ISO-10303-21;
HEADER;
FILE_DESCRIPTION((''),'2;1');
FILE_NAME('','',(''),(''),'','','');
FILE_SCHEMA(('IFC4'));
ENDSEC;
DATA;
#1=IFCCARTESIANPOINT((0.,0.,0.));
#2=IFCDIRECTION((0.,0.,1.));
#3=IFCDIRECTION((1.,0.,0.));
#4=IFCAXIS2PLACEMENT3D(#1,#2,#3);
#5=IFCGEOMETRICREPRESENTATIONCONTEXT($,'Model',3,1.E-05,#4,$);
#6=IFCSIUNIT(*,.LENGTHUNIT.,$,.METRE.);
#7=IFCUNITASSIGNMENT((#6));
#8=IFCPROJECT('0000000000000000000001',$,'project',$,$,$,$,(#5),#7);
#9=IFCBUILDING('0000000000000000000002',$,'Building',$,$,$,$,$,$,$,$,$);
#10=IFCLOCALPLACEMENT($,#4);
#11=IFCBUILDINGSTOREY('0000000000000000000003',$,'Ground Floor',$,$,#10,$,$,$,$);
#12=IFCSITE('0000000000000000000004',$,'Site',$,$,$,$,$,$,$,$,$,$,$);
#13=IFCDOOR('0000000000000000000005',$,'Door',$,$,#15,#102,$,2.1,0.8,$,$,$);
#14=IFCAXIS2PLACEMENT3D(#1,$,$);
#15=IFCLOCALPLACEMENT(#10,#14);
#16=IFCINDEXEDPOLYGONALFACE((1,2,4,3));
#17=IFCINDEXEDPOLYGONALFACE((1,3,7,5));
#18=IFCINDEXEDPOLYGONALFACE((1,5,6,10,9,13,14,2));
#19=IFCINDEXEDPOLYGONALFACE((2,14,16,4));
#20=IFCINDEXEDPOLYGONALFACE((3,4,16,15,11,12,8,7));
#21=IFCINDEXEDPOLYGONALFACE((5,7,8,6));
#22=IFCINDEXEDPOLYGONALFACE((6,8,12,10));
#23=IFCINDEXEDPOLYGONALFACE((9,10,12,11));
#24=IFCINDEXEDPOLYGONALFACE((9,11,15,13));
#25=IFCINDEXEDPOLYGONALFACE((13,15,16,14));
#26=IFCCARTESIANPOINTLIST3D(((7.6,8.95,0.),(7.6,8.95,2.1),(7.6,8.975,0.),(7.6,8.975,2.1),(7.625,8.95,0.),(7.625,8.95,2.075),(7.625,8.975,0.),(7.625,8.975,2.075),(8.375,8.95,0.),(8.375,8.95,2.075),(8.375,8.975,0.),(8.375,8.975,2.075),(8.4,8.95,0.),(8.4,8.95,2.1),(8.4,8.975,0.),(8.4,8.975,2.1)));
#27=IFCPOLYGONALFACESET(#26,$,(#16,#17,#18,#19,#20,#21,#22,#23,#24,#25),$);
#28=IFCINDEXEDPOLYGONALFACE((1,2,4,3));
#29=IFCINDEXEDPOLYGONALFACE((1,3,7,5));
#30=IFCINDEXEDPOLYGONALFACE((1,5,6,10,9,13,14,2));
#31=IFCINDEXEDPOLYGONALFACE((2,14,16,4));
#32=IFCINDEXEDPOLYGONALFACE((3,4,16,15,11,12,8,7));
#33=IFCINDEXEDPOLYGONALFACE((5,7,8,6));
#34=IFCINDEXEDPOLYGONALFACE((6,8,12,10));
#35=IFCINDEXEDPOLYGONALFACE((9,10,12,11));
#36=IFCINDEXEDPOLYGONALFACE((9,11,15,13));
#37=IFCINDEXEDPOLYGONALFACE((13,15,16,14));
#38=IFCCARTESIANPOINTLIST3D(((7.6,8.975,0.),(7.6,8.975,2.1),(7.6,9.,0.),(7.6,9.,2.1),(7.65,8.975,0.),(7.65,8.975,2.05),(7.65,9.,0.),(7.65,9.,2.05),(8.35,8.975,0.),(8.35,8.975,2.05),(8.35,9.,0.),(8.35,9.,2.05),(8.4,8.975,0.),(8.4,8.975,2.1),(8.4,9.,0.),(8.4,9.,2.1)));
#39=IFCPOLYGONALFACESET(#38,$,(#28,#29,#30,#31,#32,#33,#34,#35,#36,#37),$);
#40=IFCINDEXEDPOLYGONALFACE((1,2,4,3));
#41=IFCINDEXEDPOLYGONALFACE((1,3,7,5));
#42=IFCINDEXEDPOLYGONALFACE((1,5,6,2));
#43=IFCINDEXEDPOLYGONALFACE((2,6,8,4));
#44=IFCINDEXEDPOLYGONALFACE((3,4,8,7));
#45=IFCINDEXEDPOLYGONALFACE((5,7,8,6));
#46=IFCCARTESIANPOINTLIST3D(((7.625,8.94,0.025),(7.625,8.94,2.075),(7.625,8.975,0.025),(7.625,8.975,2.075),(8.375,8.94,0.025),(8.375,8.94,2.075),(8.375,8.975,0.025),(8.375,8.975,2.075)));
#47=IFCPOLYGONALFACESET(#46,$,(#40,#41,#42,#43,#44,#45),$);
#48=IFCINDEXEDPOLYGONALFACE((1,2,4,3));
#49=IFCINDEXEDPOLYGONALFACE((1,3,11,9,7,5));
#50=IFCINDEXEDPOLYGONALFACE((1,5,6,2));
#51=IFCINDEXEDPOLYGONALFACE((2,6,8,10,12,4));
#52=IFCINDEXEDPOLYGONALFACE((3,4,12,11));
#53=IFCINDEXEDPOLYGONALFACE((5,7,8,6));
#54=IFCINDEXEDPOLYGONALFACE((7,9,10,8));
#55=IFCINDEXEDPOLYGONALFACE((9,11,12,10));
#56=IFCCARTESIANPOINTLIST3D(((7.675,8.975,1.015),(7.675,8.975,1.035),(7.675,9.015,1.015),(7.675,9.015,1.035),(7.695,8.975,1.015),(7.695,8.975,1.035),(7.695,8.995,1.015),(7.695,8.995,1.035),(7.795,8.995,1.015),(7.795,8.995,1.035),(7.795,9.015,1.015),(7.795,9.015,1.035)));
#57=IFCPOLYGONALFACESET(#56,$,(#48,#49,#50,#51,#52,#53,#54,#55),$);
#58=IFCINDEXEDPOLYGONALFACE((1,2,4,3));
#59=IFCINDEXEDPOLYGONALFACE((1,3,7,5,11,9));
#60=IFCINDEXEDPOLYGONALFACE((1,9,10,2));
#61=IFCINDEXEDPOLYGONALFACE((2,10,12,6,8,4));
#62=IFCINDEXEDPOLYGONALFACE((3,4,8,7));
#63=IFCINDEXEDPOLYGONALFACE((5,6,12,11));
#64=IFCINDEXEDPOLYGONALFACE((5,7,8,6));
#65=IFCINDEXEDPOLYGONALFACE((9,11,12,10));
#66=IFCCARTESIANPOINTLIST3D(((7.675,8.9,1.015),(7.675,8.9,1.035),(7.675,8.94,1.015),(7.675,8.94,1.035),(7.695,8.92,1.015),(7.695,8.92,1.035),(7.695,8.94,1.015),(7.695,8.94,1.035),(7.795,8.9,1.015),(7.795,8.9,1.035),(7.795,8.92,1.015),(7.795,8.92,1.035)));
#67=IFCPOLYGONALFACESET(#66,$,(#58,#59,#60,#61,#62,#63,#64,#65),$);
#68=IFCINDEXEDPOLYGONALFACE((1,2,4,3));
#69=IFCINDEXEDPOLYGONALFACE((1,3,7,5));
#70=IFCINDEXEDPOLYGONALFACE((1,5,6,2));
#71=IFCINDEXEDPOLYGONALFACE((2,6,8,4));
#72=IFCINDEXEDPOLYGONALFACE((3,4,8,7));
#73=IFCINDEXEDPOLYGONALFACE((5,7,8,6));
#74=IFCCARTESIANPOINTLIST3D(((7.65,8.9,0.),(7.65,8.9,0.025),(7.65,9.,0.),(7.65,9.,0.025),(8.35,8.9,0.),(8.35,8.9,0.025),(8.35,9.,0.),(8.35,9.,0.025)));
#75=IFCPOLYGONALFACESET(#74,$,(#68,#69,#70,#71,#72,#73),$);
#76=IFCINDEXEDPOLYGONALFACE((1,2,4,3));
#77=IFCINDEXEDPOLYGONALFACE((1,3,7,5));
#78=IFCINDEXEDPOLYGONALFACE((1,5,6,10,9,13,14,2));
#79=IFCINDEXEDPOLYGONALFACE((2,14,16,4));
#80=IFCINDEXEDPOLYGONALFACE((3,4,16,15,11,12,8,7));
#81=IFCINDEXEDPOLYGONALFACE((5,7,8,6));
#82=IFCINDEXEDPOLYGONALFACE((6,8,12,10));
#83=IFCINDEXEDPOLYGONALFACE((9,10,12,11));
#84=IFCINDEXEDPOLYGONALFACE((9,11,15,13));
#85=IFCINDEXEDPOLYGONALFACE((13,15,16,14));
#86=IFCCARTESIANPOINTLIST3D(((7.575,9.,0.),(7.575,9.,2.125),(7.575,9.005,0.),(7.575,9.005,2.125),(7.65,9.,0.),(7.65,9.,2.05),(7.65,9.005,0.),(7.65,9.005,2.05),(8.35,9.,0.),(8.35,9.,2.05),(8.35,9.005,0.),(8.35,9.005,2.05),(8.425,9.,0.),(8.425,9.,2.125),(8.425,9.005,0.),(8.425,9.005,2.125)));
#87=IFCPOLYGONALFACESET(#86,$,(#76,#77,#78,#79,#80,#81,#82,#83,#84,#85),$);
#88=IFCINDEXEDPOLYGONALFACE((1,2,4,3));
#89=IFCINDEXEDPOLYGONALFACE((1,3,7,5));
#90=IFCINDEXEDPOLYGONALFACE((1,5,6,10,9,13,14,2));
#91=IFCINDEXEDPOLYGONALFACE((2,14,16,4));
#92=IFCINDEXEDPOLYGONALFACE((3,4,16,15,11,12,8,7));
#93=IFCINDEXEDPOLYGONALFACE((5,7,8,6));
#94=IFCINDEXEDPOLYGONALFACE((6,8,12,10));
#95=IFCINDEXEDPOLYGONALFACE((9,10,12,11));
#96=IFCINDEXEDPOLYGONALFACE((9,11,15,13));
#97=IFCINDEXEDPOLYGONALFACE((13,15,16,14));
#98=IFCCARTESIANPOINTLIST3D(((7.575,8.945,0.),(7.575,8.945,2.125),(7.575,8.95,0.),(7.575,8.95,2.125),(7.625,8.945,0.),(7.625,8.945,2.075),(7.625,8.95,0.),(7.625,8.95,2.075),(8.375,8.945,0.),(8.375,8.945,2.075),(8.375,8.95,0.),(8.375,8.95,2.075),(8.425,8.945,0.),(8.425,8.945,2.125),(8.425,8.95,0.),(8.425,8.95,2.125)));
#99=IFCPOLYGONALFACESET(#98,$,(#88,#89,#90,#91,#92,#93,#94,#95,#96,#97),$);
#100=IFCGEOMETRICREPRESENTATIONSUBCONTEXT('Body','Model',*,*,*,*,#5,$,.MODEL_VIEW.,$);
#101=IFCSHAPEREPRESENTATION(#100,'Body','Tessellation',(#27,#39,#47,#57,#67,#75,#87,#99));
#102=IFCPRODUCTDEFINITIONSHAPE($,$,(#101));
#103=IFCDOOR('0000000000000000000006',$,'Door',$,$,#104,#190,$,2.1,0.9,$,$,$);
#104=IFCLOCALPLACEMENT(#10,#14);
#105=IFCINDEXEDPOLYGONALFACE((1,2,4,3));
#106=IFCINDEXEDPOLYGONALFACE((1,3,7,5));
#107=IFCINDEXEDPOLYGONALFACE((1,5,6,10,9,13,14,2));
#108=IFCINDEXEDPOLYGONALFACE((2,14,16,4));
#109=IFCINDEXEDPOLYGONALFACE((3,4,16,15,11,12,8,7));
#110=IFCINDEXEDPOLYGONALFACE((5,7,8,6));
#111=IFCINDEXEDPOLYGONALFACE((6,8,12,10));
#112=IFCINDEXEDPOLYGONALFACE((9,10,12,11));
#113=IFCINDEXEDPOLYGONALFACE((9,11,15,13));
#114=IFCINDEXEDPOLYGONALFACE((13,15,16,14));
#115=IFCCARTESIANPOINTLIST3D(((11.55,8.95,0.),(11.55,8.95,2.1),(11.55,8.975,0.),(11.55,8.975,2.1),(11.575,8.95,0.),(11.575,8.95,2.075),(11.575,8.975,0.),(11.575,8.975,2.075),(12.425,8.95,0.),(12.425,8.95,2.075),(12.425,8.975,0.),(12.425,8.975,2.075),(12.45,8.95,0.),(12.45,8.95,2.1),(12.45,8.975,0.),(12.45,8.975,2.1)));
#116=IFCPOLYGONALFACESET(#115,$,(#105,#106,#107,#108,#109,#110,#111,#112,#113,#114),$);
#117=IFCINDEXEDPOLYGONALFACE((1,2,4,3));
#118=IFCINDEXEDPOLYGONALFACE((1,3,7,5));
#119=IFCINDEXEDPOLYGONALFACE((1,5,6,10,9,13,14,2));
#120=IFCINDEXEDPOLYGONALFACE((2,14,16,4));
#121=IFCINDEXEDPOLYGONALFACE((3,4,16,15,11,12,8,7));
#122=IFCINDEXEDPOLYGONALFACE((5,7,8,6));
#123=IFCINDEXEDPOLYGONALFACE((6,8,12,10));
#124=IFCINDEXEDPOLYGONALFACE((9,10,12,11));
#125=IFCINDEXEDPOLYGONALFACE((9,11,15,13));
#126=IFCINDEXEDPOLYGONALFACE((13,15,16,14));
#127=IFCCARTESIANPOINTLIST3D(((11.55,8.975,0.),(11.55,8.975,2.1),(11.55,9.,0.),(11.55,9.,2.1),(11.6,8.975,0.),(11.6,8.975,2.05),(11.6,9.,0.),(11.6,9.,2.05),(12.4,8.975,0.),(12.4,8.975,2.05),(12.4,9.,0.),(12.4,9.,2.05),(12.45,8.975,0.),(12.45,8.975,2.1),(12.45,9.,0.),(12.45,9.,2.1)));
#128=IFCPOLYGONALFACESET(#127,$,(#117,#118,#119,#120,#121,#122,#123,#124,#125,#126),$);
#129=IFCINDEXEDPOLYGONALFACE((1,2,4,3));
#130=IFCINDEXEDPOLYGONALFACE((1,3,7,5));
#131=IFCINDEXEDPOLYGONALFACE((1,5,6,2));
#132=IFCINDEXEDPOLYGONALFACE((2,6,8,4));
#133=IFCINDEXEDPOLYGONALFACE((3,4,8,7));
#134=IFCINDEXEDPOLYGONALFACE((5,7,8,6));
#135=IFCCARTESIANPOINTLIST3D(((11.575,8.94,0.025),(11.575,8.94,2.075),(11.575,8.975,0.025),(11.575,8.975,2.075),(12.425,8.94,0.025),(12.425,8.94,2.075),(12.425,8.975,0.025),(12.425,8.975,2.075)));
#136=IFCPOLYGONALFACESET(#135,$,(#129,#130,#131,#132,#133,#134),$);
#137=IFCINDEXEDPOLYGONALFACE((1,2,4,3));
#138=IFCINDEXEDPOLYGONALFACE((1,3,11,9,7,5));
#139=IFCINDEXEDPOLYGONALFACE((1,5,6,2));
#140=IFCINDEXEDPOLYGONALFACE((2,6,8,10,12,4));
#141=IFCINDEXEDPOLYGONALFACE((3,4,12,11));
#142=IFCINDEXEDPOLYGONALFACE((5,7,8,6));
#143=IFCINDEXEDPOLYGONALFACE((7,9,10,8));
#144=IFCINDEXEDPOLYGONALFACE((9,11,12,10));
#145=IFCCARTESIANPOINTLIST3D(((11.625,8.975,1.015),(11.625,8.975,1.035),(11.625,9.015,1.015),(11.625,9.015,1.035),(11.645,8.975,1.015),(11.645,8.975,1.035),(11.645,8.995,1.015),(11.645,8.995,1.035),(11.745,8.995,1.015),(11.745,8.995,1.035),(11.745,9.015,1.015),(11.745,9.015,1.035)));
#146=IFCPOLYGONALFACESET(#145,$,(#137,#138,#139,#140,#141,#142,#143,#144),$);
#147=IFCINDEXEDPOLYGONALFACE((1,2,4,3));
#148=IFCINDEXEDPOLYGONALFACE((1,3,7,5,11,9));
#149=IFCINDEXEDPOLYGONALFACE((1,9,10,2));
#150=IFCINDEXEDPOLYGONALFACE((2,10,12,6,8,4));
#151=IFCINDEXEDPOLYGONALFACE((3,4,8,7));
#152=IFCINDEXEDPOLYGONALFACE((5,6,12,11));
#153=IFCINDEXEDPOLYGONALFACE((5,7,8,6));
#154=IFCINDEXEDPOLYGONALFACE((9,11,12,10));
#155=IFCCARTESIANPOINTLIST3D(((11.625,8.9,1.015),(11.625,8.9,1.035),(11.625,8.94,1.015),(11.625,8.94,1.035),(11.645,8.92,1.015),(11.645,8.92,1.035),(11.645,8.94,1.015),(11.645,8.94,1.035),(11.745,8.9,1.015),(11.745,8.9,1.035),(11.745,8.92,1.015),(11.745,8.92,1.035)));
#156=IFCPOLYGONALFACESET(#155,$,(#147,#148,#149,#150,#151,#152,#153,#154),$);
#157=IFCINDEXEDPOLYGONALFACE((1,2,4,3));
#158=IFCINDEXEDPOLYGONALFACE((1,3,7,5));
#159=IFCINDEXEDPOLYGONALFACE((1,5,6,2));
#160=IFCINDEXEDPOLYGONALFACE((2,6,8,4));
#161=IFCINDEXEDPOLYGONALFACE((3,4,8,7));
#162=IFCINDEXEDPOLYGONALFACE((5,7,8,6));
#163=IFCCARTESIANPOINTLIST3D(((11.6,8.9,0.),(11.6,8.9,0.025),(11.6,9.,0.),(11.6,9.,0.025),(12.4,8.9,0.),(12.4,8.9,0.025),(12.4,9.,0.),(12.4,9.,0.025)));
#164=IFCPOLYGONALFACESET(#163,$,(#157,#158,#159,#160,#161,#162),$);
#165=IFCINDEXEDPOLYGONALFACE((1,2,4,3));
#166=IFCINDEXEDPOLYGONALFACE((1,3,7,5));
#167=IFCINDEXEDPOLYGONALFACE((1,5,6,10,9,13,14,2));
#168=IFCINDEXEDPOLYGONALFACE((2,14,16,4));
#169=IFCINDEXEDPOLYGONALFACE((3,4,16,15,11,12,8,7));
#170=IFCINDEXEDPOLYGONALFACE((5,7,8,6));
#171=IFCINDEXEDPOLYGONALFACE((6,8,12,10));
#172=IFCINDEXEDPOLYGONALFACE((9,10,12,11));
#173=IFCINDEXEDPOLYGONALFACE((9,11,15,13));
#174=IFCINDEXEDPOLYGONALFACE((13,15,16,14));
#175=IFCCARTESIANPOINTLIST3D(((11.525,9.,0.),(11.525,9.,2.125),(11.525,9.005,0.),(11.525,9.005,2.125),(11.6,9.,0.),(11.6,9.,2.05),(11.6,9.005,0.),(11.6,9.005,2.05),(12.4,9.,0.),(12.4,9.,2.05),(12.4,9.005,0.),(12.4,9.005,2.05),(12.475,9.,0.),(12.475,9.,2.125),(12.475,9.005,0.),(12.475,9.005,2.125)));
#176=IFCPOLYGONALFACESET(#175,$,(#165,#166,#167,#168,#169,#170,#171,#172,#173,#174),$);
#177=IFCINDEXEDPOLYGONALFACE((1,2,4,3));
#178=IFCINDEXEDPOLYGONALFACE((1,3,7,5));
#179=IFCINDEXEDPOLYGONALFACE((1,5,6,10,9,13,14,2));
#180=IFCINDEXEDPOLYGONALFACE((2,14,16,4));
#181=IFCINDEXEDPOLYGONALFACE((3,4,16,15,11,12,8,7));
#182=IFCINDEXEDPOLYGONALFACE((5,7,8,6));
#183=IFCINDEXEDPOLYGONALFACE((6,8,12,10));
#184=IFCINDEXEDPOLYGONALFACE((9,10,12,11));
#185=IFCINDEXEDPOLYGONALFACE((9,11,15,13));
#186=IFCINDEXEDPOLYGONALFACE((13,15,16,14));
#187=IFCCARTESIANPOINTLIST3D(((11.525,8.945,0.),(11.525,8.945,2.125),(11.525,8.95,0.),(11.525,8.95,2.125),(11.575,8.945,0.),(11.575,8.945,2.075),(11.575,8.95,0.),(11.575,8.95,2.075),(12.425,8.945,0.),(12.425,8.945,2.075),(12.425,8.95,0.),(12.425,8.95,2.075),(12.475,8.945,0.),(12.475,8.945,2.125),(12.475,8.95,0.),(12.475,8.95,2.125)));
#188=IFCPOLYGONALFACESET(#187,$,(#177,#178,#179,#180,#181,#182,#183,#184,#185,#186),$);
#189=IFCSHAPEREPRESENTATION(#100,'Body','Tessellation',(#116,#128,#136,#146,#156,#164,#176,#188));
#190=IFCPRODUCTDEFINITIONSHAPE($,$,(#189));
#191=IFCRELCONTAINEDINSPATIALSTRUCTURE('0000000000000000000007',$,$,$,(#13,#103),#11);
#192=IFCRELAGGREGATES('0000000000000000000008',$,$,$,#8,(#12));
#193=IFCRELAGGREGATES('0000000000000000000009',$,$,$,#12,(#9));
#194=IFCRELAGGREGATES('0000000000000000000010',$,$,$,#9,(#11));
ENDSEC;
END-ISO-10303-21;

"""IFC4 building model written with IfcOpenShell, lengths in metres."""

from ifc_helpers import new_model, si_unit, frame, origin_with_axes, place, context, subcontext, project, spatial, line, indexed_curve, outline, extrude, element, save


model = new_model("IFC4")

# Units and contexts
model_context = context("Model", 3, precision=1e-05, world=origin_with_axes())
body_context = subcontext(model_context, "Body", "Model", "MODEL_VIEW")
ifc_project = project(units=[si_unit("LENGTHUNIT", "METRE")], contexts=[model_context])

# Site, building, storey
site = spatial("IfcSite", under=ifc_project, Name="Site")
building = spatial("IfcBuilding", under=site, Name="Building")
storey_placement = place(None, origin_with_axes())
storey = spatial("IfcBuildingStorey", under=building, at=storey_placement, Name="Ground Floor")

# Doors
door_1_placement = place(storey_placement, frame((8.4, 9.0, 0.0), z_axis=(0.0, 0.0, 1.0), x_axis=(-1.0, 0.0, 0.0)))
element("IfcDoor", 1, at=door_1_placement, inside=storey, Name="Door", OverallHeight=2.1, OverallWidth=0.8, context=body_context, shape_type="SweptSolid", body=[
    extrude(outline(indexed_curve([(0.0, 0.0), (0.0, 2.1), (0.8, 2.1), (0.8, 0.0), (0.775, 0.0), (0.775, 2.075), (0.025, 2.075), (0.025, 0.0)], segments=[line(1, 2, 3, 4, 5, 6, 7, 8, 1)])), frame((0.0, 0.025, 0.0), z_axis=(0.0, -1.0, 0.0), x_axis=(1.0, 0.0, 0.0)), (0.0, 0.0, -1.0), 0.025),
    extrude(outline(indexed_curve([(0.0, 0.0), (0.0, 2.1), (0.8, 2.1), (0.8, 0.0), (0.75, 0.0), (0.75, 2.05), (0.05, 2.05), (0.05, 0.0)], segments=[line(1, 2, 3, 4, 5, 6, 7, 8, 1)])), frame((0.0, 0.0, 0.0), z_axis=(0.0, -1.0, 0.0), x_axis=(1.0, 0.0, 0.0)), (0.0, 0.0, -1.0), 0.025),
    extrude(outline(indexed_curve([(0.0, 0.0), (0.75, 0.0), (0.75, 0.035), (0.0, 0.035)], segments=[line(1, 2, 3, 4, 1)])), frame((0.025, 0.025, 0.025), z_axis=(0.0, 0.0, 1.0), x_axis=(1.0, 0.0, 0.0)), (0.0, 0.0, 1.0), 2.05),
    extrude(outline(indexed_curve([(0.0, 0.0), (0.0, -0.04), (-0.12, -0.04), (-0.12, -0.02), (-0.02, -0.02), (-0.02, 0.0)], segments=[line(1, 2, 3, 4, 5, 6, 1)])), frame((0.725, 0.025, 1.015), z_axis=(0.0, 0.0, 1.0), x_axis=(1.0, 0.0, 0.0)), (0.0, 0.0, 1.0), 0.02),
    extrude(outline(indexed_curve([(0.0, 0.0), (0.0, 0.04), (-0.12, 0.04), (-0.12, 0.02), (-0.02, 0.02), (-0.02, 0.0)], segments=[line(1, 2, 3, 4, 5, 6, 1)])), frame((0.725, 0.06, 1.015), z_axis=(0.0, 0.0, 1.0), x_axis=(1.0, 0.0, 0.0)), (0.0, 0.0, 1.0), 0.02),
    extrude(outline(indexed_curve([(0.0, 0.0), (0.7, 0.0), (0.7, 0.1), (0.0, 0.1)], segments=[line(1, 2, 3, 4, 1)])), frame((0.05, 0.0, 0.0), z_axis=(0.0, 0.0, 1.0), x_axis=(1.0, 0.0, 0.0)), (0.0, 0.0, 1.0), 0.025),
    extrude(outline(indexed_curve([(0.0, 0.0), (0.0, 2.125), (0.85, 2.125), (0.85, 0.0), (0.775, 0.0), (0.775, 2.05), (0.075, 2.05), (0.075, 0.0)], segments=[line(1, 2, 3, 4, 5, 6, 7, 8, 1)])), frame((-0.025, -0.005, 0.0), z_axis=(0.0, -1.0, 0.0), x_axis=(1.0, 0.0, 0.0)), (0.0, 0.0, -1.0), 0.005),
    extrude(outline(indexed_curve([(0.0, 0.0), (0.0, 2.125), (0.85, 2.125), (0.85, 0.0), (0.8, 0.0), (0.8, 2.075), (0.05, 2.075), (0.05, 0.0)], segments=[line(1, 2, 3, 4, 5, 6, 7, 8, 1)])), frame((-0.025, 0.05, 0.0), z_axis=(0.0, -1.0, 0.0), x_axis=(1.0, 0.0, 0.0)), (0.0, 0.0, -1.0), 0.005),
])
door_2_placement = place(storey_placement, frame((12.45, 9.0, 0.0), z_axis=(0.0, 0.0, 1.0), x_axis=(-1.0, 0.0, 0.0)))
element("IfcDoor", 2, at=door_2_placement, inside=storey, Name="Door", OverallHeight=2.1, OverallWidth=0.9, context=body_context, shape_type="SweptSolid", body=[
    extrude(outline(indexed_curve([(0.0, 0.0), (0.0, 2.1), (0.9, 2.1), (0.9, 0.0), (0.875, 0.0), (0.875, 2.075), (0.025, 2.075), (0.025, 0.0)], segments=[line(1, 2, 3, 4, 5, 6, 7, 8, 1)])), frame((0.0, 0.025, 0.0), z_axis=(0.0, -1.0, 0.0), x_axis=(1.0, 0.0, 0.0)), (0.0, 0.0, -1.0), 0.025),
    extrude(outline(indexed_curve([(0.0, 0.0), (0.0, 2.1), (0.9, 2.1), (0.9, 0.0), (0.85, 0.0), (0.85, 2.05), (0.05, 2.05), (0.05, 0.0)], segments=[line(1, 2, 3, 4, 5, 6, 7, 8, 1)])), frame((0.0, 0.0, 0.0), z_axis=(0.0, -1.0, 0.0), x_axis=(1.0, 0.0, 0.0)), (0.0, 0.0, -1.0), 0.025),
    extrude(outline(indexed_curve([(0.0, 0.0), (0.85, 0.0), (0.85, 0.035), (0.0, 0.035)], segments=[line(1, 2, 3, 4, 1)])), frame((0.025, 0.025, 0.025), z_axis=(0.0, 0.0, 1.0), x_axis=(1.0, 0.0, 0.0)), (0.0, 0.0, 1.0), 2.05),
    extrude(outline(indexed_curve([(0.0, 0.0), (0.0, -0.04), (-0.12, -0.04), (-0.12, -0.02), (-0.02, -0.02), (-0.02, 0.0)], segments=[line(1, 2, 3, 4, 5, 6, 1)])), frame((0.825, 0.025, 1.015), z_axis=(0.0, 0.0, 1.0), x_axis=(1.0, 0.0, 0.0)), (0.0, 0.0, 1.0), 0.02),
    extrude(outline(indexed_curve([(0.0, 0.0), (0.0, 0.04), (-0.12, 0.04), (-0.12, 0.02), (-0.02, 0.02), (-0.02, 0.0)], segments=[line(1, 2, 3, 4, 5, 6, 1)])), frame((0.825, 0.06, 1.015), z_axis=(0.0, 0.0, 1.0), x_axis=(1.0, 0.0, 0.0)), (0.0, 0.0, 1.0), 0.02),
    extrude(outline(indexed_curve([(0.0, 0.0), (0.8, 0.0), (0.8, 0.1), (0.0, 0.1)], segments=[line(1, 2, 3, 4, 1)])), frame((0.05, 0.0, 0.0), z_axis=(0.0, 0.0, 1.0), x_axis=(1.0, 0.0, 0.0)), (0.0, 0.0, 1.0), 0.025),
    extrude(outline(indexed_curve([(0.0, 0.0), (0.0, 2.125), (0.95, 2.125), (0.95, 0.0), (0.875, 0.0), (0.875, 2.05), (0.075, 2.05), (0.075, 0.0)], segments=[line(1, 2, 3, 4, 5, 6, 7, 8, 1)])), frame((-0.025, -0.005, 0.0), z_axis=(0.0, -1.0, 0.0), x_axis=(1.0, 0.0, 0.0)), (0.0, 0.0, -1.0), 0.005),
    extrude(outline(indexed_curve([(0.0, 0.0), (0.0, 2.125), (0.95, 2.125), (0.95, 0.0), (0.9, 0.0), (0.9, 2.075), (0.05, 2.075), (0.05, 0.0)], segments=[line(1, 2, 3, 4, 5, 6, 7, 8, 1)])), frame((-0.025, 0.05, 0.0), z_axis=(0.0, -1.0, 0.0), x_axis=(1.0, 0.0, 0.0)), (0.0, 0.0, -1.0), 0.005),
])

save(model, "model.ifc")
